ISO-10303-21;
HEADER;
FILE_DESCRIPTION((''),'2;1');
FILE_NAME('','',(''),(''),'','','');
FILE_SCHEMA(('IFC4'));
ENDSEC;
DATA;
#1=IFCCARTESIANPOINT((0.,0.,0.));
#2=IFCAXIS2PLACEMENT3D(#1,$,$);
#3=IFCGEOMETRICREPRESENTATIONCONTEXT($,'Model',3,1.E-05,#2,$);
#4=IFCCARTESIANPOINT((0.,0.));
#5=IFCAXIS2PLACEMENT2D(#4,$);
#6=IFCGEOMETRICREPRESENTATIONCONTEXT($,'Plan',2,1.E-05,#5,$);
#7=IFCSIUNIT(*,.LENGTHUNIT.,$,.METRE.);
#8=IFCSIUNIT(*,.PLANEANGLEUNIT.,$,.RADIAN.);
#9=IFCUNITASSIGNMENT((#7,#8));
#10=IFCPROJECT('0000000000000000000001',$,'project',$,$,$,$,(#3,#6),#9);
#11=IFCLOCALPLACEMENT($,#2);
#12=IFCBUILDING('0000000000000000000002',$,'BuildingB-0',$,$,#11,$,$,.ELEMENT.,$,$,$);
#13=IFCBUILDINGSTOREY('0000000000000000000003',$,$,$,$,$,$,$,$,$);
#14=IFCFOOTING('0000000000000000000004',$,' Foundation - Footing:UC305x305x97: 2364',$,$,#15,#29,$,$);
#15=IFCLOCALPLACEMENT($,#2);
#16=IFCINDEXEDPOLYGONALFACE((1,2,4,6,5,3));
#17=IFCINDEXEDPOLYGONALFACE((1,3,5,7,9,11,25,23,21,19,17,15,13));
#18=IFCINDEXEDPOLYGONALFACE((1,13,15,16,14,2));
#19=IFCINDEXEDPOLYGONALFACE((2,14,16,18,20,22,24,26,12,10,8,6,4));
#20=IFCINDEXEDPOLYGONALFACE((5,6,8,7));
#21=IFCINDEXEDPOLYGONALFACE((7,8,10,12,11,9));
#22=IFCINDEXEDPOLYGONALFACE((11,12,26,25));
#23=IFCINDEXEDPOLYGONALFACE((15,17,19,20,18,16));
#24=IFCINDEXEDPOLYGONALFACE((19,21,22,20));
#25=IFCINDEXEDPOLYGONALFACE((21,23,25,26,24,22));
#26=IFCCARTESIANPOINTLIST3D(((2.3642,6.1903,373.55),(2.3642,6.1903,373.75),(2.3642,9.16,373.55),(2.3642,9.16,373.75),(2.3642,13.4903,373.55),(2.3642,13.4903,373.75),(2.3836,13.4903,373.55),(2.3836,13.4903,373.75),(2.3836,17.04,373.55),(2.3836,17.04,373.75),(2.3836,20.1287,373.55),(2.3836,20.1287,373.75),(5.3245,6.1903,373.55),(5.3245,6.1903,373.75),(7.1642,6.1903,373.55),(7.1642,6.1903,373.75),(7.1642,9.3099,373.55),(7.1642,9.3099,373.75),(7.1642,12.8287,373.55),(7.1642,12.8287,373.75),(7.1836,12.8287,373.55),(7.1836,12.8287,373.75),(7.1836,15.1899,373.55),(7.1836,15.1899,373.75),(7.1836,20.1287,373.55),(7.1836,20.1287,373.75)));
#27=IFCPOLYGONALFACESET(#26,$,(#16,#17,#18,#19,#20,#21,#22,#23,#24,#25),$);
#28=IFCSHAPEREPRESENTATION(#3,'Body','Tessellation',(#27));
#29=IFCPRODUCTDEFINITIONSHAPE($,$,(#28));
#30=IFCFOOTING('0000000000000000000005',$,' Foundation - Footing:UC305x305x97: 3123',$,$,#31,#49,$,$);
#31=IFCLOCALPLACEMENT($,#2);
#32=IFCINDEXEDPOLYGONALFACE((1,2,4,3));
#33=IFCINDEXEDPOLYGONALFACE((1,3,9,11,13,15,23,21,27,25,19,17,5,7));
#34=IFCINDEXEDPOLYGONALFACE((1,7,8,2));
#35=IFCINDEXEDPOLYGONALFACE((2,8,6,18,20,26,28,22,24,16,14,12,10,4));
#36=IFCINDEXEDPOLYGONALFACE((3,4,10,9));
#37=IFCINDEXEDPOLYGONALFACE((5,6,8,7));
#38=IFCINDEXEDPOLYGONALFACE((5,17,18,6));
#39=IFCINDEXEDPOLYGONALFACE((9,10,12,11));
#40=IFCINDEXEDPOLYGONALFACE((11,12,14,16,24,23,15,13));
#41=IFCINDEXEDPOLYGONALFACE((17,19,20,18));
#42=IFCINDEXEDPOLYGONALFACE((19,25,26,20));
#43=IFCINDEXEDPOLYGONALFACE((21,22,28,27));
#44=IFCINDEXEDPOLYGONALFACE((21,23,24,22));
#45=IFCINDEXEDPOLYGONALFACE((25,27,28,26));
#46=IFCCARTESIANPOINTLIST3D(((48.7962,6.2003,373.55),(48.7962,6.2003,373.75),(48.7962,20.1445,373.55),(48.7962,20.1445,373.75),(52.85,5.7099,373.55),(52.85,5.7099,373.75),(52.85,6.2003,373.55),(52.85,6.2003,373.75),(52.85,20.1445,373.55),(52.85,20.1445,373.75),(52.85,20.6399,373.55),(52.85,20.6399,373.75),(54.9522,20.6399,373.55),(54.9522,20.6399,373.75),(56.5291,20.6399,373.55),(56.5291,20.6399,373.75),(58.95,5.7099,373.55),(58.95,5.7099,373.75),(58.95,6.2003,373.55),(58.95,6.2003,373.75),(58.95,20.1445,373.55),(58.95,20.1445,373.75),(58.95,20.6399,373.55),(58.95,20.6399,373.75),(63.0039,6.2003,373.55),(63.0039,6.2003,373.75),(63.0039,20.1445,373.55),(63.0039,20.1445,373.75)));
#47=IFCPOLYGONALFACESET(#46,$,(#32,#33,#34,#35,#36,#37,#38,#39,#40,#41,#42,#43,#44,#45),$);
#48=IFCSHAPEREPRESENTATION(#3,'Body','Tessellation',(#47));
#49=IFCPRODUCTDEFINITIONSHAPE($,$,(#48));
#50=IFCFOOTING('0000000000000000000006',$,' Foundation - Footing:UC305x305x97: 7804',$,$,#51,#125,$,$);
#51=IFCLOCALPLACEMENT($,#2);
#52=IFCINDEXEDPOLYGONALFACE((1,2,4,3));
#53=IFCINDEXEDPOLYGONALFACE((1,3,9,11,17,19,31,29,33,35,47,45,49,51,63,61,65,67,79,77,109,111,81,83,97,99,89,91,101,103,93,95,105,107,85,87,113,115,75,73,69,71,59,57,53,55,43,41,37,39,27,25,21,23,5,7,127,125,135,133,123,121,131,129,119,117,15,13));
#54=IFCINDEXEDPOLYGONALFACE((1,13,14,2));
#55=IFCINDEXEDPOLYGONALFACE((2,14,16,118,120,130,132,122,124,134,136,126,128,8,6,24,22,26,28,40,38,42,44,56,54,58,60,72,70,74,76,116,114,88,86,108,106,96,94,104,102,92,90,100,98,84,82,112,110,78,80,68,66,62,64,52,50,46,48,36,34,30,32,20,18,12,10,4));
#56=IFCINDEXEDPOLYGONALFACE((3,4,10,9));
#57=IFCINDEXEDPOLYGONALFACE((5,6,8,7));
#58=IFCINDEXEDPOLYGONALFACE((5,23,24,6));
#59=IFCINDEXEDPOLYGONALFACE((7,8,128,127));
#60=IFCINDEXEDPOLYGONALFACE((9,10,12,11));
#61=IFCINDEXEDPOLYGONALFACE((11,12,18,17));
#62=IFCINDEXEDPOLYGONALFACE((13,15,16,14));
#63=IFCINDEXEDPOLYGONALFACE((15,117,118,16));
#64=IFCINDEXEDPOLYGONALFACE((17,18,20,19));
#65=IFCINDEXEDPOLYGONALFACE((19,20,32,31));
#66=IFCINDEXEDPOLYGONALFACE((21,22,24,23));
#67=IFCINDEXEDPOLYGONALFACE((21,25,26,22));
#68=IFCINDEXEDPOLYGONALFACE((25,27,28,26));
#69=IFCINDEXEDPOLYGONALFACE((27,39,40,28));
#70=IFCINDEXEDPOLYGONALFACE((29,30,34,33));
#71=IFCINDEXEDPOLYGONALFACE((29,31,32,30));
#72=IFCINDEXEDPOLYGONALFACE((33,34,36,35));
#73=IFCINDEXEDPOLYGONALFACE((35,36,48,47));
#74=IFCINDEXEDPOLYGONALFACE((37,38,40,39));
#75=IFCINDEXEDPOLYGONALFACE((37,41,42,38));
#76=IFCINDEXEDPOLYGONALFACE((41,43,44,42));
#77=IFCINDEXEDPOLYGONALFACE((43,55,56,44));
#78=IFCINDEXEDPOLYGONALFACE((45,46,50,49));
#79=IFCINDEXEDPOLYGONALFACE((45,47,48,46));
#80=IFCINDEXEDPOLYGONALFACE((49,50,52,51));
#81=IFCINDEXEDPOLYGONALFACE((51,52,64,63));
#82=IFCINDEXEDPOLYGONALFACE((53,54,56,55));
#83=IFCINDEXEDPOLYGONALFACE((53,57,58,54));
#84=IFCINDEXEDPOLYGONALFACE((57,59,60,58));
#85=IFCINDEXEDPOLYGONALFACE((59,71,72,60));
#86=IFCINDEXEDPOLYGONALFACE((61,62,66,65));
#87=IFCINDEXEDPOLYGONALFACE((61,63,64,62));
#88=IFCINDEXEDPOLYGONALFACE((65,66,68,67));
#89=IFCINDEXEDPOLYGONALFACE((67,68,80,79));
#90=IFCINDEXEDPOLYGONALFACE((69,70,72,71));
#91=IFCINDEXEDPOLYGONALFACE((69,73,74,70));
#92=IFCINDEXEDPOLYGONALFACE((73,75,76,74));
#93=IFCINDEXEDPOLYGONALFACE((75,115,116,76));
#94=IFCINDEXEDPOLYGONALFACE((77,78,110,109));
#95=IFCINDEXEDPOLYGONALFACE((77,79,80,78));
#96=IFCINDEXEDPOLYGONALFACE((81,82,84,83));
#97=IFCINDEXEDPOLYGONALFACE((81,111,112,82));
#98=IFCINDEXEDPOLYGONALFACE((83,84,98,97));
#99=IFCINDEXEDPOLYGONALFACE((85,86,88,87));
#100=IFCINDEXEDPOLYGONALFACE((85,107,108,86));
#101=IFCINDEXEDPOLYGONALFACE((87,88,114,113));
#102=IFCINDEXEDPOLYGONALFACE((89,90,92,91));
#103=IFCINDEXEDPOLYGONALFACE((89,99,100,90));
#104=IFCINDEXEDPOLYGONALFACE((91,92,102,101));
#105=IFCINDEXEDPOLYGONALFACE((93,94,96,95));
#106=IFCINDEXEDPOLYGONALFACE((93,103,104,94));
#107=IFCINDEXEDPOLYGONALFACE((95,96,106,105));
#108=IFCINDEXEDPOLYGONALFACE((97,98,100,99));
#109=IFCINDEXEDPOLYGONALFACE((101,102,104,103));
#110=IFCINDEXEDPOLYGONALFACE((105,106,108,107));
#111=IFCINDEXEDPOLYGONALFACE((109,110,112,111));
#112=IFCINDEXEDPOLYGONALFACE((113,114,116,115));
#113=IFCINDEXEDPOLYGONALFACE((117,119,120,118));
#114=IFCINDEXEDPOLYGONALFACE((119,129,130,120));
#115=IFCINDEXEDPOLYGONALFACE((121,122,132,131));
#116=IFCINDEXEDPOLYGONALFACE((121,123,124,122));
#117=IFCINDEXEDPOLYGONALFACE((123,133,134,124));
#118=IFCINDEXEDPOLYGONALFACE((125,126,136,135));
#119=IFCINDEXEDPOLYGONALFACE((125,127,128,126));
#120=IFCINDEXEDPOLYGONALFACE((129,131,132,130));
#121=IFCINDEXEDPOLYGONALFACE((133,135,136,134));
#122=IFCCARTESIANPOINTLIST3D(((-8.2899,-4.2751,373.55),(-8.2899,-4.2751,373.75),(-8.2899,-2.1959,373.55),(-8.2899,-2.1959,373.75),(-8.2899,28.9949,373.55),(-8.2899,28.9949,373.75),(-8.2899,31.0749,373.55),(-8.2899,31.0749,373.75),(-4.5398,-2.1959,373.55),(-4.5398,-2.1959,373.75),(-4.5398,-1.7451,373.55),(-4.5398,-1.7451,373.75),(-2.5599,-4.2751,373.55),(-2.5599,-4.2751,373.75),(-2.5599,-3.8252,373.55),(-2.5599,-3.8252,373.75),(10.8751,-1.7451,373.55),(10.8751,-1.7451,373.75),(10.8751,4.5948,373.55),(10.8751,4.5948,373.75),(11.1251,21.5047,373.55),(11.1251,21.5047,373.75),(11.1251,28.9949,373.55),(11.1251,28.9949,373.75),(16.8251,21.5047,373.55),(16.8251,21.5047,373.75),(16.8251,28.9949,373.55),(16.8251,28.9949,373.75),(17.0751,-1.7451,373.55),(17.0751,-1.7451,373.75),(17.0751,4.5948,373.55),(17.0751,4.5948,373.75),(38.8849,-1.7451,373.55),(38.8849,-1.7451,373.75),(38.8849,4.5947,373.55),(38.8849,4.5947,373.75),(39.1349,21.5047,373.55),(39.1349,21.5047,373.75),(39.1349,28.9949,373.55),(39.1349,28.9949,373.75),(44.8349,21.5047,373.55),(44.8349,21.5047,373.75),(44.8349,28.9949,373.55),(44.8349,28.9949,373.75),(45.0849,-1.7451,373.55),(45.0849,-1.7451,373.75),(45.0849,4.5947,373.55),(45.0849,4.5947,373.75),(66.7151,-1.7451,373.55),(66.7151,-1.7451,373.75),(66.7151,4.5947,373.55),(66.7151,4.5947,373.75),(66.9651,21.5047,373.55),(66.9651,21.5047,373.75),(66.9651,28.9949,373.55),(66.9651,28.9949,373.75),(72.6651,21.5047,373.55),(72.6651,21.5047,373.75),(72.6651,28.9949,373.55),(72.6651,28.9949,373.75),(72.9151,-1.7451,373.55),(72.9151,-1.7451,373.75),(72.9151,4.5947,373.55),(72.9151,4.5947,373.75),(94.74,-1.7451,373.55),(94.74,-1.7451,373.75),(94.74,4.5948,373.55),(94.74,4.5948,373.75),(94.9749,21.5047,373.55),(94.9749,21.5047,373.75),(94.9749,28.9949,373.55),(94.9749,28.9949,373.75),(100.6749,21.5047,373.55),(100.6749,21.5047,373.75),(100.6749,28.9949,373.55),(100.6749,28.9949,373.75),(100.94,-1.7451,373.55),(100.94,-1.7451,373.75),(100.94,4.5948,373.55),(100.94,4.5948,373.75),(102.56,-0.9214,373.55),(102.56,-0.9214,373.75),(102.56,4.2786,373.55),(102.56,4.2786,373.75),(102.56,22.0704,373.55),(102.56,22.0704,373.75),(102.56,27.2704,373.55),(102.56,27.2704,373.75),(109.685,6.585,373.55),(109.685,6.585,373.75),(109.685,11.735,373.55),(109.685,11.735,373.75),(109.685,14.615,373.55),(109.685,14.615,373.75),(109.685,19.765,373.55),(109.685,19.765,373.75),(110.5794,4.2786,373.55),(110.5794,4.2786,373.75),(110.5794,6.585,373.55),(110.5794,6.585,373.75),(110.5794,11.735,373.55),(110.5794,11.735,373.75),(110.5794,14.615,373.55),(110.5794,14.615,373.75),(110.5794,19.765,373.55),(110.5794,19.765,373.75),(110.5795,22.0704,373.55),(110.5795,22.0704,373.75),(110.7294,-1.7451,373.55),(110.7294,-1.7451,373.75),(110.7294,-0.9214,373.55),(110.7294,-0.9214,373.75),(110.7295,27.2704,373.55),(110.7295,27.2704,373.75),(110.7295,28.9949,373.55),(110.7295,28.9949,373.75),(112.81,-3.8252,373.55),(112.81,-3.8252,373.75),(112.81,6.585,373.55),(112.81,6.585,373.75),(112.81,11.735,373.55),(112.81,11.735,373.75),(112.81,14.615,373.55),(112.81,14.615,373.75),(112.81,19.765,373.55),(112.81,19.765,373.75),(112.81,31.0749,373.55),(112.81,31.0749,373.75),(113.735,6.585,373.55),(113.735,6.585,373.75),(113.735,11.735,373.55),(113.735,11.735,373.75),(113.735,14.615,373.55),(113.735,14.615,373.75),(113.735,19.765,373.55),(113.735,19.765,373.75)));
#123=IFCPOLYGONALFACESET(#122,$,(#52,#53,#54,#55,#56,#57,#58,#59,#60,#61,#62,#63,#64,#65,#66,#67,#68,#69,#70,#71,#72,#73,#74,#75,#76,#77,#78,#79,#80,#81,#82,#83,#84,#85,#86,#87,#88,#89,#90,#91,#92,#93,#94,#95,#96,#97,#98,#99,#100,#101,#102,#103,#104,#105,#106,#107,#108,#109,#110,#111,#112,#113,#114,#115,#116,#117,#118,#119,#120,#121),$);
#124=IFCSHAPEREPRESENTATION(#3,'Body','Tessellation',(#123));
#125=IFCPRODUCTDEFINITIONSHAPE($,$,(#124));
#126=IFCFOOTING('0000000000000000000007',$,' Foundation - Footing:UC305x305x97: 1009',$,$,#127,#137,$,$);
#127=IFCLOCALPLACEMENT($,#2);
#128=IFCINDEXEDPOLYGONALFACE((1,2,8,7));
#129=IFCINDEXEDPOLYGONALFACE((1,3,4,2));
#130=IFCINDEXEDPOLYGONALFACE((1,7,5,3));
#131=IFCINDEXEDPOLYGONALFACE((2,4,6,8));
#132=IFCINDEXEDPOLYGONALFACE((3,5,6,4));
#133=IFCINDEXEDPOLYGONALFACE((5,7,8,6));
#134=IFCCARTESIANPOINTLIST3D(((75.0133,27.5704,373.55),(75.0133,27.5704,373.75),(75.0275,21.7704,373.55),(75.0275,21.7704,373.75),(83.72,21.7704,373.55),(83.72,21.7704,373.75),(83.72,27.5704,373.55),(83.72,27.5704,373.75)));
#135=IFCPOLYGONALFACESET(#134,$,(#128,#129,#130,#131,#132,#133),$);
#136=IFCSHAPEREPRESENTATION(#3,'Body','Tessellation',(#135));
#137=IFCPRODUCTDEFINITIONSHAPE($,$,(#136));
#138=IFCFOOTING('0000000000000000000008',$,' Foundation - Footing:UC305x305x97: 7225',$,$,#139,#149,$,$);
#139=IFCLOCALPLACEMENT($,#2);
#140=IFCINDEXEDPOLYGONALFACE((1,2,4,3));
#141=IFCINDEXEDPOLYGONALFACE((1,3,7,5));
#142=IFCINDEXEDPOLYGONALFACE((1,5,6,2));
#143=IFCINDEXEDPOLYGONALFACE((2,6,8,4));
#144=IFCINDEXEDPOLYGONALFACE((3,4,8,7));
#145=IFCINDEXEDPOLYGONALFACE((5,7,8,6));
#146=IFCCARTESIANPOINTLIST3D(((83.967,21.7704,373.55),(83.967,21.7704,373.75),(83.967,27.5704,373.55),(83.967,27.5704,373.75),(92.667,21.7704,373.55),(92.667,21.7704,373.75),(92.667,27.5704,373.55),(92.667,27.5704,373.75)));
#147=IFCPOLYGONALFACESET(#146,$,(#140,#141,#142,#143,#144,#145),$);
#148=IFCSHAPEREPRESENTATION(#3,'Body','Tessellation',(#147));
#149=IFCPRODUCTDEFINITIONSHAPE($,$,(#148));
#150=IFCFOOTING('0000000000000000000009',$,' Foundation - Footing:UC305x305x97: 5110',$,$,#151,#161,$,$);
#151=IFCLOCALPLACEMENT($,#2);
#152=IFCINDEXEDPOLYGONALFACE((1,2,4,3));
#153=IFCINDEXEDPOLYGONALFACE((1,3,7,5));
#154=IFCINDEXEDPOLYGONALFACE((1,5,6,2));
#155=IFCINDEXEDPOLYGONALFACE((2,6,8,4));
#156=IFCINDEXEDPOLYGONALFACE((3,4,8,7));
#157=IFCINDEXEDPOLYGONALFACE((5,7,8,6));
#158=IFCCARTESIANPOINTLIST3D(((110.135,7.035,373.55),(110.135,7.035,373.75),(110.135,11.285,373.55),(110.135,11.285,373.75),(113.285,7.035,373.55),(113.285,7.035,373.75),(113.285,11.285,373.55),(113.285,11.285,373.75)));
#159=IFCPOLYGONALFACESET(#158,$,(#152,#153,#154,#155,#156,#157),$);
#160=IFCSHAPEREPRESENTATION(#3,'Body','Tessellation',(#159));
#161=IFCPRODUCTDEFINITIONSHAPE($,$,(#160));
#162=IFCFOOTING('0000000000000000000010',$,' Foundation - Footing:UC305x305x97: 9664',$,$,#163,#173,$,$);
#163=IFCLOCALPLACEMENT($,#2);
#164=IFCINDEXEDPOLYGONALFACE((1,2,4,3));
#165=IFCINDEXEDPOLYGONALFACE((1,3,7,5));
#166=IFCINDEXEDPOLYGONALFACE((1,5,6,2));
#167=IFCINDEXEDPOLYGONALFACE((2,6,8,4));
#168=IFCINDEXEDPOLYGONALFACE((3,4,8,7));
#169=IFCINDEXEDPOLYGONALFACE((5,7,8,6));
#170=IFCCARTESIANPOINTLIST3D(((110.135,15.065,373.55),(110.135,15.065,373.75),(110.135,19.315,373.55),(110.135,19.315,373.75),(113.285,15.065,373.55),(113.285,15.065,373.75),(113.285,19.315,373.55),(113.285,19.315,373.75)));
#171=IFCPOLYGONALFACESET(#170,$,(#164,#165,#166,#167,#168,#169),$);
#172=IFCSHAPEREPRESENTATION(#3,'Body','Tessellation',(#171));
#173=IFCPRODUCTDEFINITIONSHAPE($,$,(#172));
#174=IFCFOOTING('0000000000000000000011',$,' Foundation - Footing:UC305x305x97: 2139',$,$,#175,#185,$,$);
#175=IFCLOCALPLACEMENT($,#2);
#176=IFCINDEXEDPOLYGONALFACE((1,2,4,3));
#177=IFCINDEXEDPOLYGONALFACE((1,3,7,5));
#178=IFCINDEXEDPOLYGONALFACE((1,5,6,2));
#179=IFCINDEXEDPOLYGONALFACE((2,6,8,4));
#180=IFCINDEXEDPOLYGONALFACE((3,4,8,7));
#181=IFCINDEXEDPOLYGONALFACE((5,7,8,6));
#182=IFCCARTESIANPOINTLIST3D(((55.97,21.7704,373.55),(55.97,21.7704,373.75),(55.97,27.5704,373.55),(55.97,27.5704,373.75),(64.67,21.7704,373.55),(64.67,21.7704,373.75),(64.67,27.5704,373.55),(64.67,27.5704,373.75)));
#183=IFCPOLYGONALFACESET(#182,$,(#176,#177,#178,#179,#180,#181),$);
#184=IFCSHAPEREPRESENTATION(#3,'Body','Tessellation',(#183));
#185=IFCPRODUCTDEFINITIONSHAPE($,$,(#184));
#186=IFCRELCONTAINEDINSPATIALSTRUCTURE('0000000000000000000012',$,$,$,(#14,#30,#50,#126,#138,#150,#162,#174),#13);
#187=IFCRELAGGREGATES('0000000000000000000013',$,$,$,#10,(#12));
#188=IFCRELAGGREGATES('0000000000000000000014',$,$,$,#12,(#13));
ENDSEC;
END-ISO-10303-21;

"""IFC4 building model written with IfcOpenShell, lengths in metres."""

from ifc_helpers import new_model, si_unit, origin, origin_2d, place, context, project, spatial, polyline, outline, extrude, element, save


model = new_model("IFC4")

# Units and contexts
model_context = context("Model", 3, precision=1e-05, world=origin())
plan_context = context("Plan", 2, precision=1e-05, world=origin_2d())
ifc_project = project(units=[si_unit("LENGTHUNIT", "METRE"), si_unit("PLANEANGLEUNIT", "RADIAN")], contexts=[model_context, plan_context])

# Building, storey
building_placement = place(None, origin())
building = spatial("IfcBuilding", under=ifc_project, at=building_placement, Name="BuildingB-0", CompositionType="ELEMENT")
storey = spatial("IfcBuildingStorey", under=building)

# Footings
element("IfcFooting", 1, inside=storey, Name=" Foundation - Footing:UC305x305x97: 2364", context=model_context, shape_type="SweptSolid", body=[
    extrude(outline(polyline([(7.1642, 12.8287, 373.55), (7.1836, 12.8287, 373.55), (7.1836, 15.1899, 373.55), (7.1836, 20.1287, 373.55), (2.3836, 20.1287, 373.55), (2.3836, 17.04, 373.55), (2.3836, 13.4903, 373.55), (2.3642, 13.4903, 373.55), (2.3642, 9.16, 373.55), (2.3642, 6.1903, 373.55), (5.3245, 6.1903, 373.55), (7.1642, 6.1903, 373.55), (7.1642, 9.3099, 373.55), (7.1642, 12.8287, 373.55)])), None, (0.0, 0.0, 1.0), 0.2),
])
element("IfcFooting", 2, inside=storey, Name=" Foundation - Footing:UC305x305x97: 3123", context=model_context, shape_type="SweptSolid", body=[
    extrude(outline(polyline([(58.95, 5.7099, 373.55), (58.95, 6.2003, 373.55), (63.0039, 6.2003, 373.55), (63.0039, 20.1445, 373.55), (58.95, 20.1445, 373.55), (58.95, 20.6399, 373.55), (56.5291, 20.6399, 373.55), (54.9522, 20.6399, 373.55), (52.85, 20.6399, 373.55), (52.85, 20.1445, 373.55), (48.7962, 20.1445, 373.55), (48.7962, 6.2003, 373.55), (52.85, 6.2003, 373.55), (52.85, 5.7099, 373.55), (58.95, 5.7099, 373.55)])), None, (0.0, 0.0, 1.0), 0.2),
])
element("IfcFooting", 3, inside=storey, Name=" Foundation - Footing:UC305x305x97: 7804", context=model_context, shape_type="SweptSolid", body=[
    extrude(outline(polyline([(-8.2899, 31.0749, 373.55), (-8.2899, 28.9949, 373.55), (11.1251, 28.9949, 373.55), (11.1251, 21.5047, 373.55), (16.8251, 21.5047, 373.55), (16.8251, 28.9949, 373.55), (39.1349, 28.9949, 373.55), (39.1349, 21.5047, 373.55), (44.8349, 21.5047, 373.55), (44.8349, 28.9949, 373.55), (66.9651, 28.9949, 373.55), (66.9651, 21.5047, 373.55), (72.6651, 21.5047, 373.55), (72.6651, 28.9949, 373.55), (94.9749, 28.9949, 373.55), (94.9749, 21.5047, 373.55), (100.6749, 21.5047, 373.55), (100.6749, 28.9949, 373.55), (110.7295, 28.9949, 373.55), (110.7295, 27.2704, 373.55), (102.56, 27.2704, 373.55), (102.56, 22.0704, 373.55), (110.5795, 22.0704, 373.55), (110.5794, 19.765, 373.55), (109.685, 19.765, 373.55), (109.685, 14.615, 373.55), (110.5794, 14.615, 373.55), (110.5794, 11.735, 373.55), (109.685, 11.735, 373.55), (109.685, 6.585, 373.55), (110.5794, 6.585, 373.55), (110.5794, 4.2786, 373.55), (102.56, 4.2786, 373.55), (102.56, -0.9214, 373.55), (110.7294, -0.9214, 373.55), (110.7294, -1.7451, 373.55), (100.94, -1.7451, 373.55), (100.94, 4.5948, 373.55), (94.74, 4.5948, 373.55), (94.74, -1.7451, 373.55), (72.9151, -1.7451, 373.55), (72.9151, 4.5947, 373.55), (66.7151, 4.5947, 373.55), (66.7151, -1.7451, 373.55), (45.0849, -1.7451, 373.55), (45.0849, 4.5947, 373.55), (38.8849, 4.5947, 373.55), (38.8849, -1.7451, 373.55), (17.0751, -1.7451, 373.55), (17.0751, 4.5948, 373.55), (10.8751, 4.5948, 373.55), (10.8751, -1.7451, 373.55), (-4.5398, -1.7451, 373.55), (-4.5398, -2.1959, 373.55), (-8.2899, -2.1959, 373.55), (-8.2899, -4.2751, 373.55), (-2.5599, -4.2751, 373.55), (-2.5599, -3.8252, 373.55), (112.81, -3.8252, 373.55), (112.81, 6.585, 373.55), (113.735, 6.585, 373.55), (113.735, 11.735, 373.55), (112.81, 11.735, 373.55), (112.81, 14.615, 373.55), (113.735, 14.615, 373.55), (113.735, 19.765, 373.55), (112.81, 19.765, 373.55), (112.81, 31.0749, 373.55), (-8.2899, 31.0749, 373.55)])), None, (0.0, 0.0, 1.0), 0.2),
])
element("IfcFooting", 4, inside=storey, Name=" Foundation - Footing:UC305x305x97: 1009", context=model_context, shape_type="SweptSolid", body=[
    extrude(outline(polyline([(75.0275, 21.7704, 373.55), (83.72, 21.7704, 373.55), (83.72, 27.5704, 373.55), (75.0133, 27.5704, 373.55), (75.0275, 21.7704, 373.55)])), None, (0.0, 0.0, 1.0), 0.2),
])
element("IfcFooting", 5, inside=storey, Name=" Foundation - Footing:UC305x305x97: 7225", context=model_context, shape_type="SweptSolid", body=[
    extrude(outline(polyline([(83.967, 21.7704, 373.55), (92.667, 21.7704, 373.55), (92.667, 27.5704, 373.55), (83.967, 27.5704, 373.55), (83.967, 21.7704, 373.55)])), None, (0.0, 0.0, 1.0), 0.2),
])
element("IfcFooting", 6, inside=storey, Name=" Foundation - Footing:UC305x305x97: 5110", context=model_context, shape_type="SweptSolid", body=[
    extrude(outline(polyline([(110.135, 11.285, 373.55), (113.285, 11.285, 373.55), (113.285, 7.035, 373.55), (110.135, 7.035, 373.55), (110.135, 11.285, 373.55)])), None, (0.0, 0.0, 1.0), 0.2),
])
element("IfcFooting", 7, inside=storey, Name=" Foundation - Footing:UC305x305x97: 9664", context=model_context, shape_type="SweptSolid", body=[
    extrude(outline(polyline([(110.135, 19.315, 373.55), (113.285, 19.315, 373.55), (113.285, 15.065, 373.55), (110.135, 15.065, 373.55), (110.135, 19.315, 373.55)])), None, (0.0, 0.0, 1.0), 0.2),
])
element("IfcFooting", 8, inside=storey, Name=" Foundation - Footing:UC305x305x97: 2139", context=model_context, shape_type="SweptSolid", body=[
    extrude(outline(polyline([(55.97, 27.5704, 373.55), (64.67, 27.5704, 373.55), (64.67, 21.7704, 373.55), (55.97, 21.7704, 373.55), (55.97, 27.5704, 373.55)])), None, (0.0, 0.0, 1.0), 0.2),
])

save(model, "model.ifc")
